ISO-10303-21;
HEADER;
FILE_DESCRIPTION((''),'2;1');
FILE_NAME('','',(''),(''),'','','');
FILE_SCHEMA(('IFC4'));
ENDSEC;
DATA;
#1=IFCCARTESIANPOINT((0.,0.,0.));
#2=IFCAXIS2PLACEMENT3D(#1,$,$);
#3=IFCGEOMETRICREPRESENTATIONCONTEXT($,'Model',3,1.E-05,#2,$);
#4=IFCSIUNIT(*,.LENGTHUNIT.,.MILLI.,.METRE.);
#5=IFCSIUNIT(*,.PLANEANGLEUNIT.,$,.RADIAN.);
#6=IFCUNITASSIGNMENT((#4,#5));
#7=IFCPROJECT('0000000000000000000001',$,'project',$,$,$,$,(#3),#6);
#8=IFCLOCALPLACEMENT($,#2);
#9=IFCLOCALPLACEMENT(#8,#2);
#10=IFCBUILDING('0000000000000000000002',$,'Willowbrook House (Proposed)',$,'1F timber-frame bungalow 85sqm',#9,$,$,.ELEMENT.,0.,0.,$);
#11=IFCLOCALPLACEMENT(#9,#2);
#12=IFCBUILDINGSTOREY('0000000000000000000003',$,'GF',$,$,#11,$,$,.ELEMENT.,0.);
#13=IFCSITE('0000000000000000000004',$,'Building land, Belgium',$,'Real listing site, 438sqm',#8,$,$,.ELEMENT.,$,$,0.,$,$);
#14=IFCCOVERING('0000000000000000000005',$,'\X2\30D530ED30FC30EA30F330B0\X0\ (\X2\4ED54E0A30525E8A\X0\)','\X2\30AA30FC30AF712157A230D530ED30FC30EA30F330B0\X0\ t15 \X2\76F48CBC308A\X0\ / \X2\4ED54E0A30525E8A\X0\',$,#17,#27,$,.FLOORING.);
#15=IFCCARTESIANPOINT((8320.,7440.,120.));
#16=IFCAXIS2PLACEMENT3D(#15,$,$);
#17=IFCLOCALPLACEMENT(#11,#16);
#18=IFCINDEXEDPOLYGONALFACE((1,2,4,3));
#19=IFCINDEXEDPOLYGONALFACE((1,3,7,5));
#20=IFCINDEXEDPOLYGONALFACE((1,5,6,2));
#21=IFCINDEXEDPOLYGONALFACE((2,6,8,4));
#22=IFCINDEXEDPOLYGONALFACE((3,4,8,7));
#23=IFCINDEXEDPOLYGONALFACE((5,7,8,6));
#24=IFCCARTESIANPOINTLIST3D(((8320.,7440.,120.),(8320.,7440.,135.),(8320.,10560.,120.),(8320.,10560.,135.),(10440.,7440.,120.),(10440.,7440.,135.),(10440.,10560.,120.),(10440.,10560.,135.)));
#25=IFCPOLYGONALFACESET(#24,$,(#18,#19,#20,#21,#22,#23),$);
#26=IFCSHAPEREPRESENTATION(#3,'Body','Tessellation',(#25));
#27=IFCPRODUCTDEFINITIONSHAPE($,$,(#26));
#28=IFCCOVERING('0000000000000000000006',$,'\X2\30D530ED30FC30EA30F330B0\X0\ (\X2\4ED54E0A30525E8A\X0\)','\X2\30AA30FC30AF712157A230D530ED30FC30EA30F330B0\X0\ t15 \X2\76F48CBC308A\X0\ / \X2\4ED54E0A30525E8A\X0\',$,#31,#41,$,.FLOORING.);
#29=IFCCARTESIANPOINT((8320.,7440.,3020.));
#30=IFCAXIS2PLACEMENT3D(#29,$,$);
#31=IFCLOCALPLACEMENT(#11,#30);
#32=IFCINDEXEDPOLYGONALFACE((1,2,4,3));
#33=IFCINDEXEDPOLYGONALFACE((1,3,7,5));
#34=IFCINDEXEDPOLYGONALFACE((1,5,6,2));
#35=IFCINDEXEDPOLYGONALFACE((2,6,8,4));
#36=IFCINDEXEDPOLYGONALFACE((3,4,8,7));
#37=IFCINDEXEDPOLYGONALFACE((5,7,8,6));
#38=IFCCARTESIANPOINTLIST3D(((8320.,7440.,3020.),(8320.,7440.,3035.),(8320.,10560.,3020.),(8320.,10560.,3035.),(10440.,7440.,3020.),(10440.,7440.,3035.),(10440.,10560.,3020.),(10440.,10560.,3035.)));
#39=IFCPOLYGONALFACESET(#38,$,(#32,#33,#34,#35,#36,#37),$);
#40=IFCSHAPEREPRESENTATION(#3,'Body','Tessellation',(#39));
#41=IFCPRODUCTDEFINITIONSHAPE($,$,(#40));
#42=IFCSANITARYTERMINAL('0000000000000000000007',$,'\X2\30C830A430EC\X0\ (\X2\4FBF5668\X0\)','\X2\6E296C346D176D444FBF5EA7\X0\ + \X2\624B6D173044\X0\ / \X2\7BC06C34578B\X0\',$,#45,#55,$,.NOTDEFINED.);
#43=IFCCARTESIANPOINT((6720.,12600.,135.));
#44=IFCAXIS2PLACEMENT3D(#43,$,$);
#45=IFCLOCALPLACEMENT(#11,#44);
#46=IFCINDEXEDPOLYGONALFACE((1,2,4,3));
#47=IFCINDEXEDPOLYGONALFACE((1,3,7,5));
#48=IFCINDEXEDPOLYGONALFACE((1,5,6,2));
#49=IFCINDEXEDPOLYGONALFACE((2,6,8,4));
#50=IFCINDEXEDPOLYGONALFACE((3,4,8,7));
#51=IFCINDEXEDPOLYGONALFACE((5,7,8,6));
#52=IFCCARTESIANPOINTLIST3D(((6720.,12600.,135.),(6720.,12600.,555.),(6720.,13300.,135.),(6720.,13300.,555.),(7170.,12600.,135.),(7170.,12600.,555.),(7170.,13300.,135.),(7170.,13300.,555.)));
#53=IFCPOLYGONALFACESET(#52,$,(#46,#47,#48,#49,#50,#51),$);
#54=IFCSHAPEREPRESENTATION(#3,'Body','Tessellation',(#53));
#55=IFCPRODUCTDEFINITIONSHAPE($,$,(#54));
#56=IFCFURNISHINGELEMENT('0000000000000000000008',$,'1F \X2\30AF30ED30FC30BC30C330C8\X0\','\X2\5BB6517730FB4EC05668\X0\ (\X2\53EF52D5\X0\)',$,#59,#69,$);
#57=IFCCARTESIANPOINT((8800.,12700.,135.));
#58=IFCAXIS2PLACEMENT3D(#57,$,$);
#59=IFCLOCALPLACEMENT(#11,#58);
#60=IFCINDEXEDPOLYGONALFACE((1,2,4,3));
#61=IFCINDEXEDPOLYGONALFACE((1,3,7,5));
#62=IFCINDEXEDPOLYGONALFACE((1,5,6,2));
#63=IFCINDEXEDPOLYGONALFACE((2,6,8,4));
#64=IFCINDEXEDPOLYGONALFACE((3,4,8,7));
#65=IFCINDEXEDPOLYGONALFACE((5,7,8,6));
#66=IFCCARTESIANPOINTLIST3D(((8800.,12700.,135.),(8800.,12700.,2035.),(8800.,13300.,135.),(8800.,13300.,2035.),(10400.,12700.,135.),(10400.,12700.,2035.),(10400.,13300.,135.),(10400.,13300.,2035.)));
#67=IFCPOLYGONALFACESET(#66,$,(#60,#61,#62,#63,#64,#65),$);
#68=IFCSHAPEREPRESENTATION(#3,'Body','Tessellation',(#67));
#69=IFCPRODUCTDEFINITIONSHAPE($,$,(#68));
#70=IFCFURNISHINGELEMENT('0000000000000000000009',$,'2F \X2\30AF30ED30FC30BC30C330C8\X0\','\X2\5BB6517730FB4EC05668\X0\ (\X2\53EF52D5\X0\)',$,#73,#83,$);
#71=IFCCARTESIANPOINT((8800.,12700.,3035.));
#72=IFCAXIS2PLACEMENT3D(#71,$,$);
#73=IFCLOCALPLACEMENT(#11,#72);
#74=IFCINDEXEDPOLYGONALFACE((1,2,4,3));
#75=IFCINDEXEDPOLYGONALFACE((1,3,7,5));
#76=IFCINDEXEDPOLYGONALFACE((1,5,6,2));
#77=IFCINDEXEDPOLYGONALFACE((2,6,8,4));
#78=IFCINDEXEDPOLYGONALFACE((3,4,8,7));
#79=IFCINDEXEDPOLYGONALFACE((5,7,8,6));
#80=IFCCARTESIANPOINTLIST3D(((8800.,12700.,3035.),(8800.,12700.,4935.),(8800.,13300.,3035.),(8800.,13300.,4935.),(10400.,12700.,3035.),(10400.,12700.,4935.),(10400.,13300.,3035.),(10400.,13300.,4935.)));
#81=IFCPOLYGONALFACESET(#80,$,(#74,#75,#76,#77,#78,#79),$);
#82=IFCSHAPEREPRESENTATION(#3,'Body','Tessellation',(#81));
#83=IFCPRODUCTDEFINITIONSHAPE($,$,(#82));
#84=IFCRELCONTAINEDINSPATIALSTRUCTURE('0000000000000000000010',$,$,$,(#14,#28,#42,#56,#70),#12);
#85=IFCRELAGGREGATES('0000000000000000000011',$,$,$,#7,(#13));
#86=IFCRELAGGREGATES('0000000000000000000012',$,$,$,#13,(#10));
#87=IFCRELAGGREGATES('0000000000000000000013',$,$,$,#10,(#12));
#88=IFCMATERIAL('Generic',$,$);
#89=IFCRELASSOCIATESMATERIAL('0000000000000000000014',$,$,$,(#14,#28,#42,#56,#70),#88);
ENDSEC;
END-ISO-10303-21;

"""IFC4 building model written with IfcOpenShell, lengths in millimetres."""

from ifc_helpers import new_model, si_unit, frame, frame_2d, origin, place, context, project, spatial, rectangle, extrude, material, element, save


model = new_model("IFC4")

# Units and contexts
model_context = context("Model", 3, precision=1e-05, world=origin())
ifc_project = project(units=[si_unit("LENGTHUNIT", "METRE", prefix="MILLI"), si_unit("PLANEANGLEUNIT", "RADIAN")], contexts=[model_context])

# Site, building, storey
site_placement = place(None, origin())
site = spatial("IfcSite", under=ifc_project, at=site_placement, Name="Building land, Belgium", ObjectType="Real listing site, 438sqm", CompositionType="ELEMENT", RefElevation=0.0)
building_placement = place(site_placement, origin())
building = spatial("IfcBuilding", under=site, at=building_placement, Name="Willowbrook House (Proposed)", ObjectType="1F timber-frame bungalow 85sqm", CompositionType="ELEMENT", ElevationOfRefHeight=0.0, ElevationOfTerrain=0.0)
storey_placement = place(building_placement, origin())
storey = spatial("IfcBuildingStorey", under=building, at=storey_placement, Name="GF", CompositionType="ELEMENT", Elevation=0.0)

# Shared definitions
ifc_material_1 = material(Name="Generic")

# Coverings
covering_1_placement = place(storey_placement, frame((8320.0, 7440.0, 120.0)))
element("IfcCovering", 1, at=covering_1_placement, inside=storey, material=ifc_material_1, Name="フローリング (仕上げ床)", Description="オーク無垢フローリング t15 直貼り / 仕上げ床", PredefinedType="FLOORING", context=model_context, shape_type="SweptSolid", body=[
    extrude(rectangle(XDim=2120.0, YDim=3120.0, at=frame_2d((1060.0, 1560.0))), frame((8320.0, 7440.0, 120.0)), (0.0, 0.0, 1.0), 15.0),
])
covering_2_placement = place(storey_placement, frame((8320.0, 7440.0, 3020.0)))
element("IfcCovering", 2, at=covering_2_placement, inside=storey, material=ifc_material_1, Name="フローリング (仕上げ床)", Description="オーク無垢フローリング t15 直貼り / 仕上げ床", PredefinedType="FLOORING", context=model_context, shape_type="SweptSolid", body=[
    extrude(rectangle(XDim=2120.0, YDim=3120.0, at=frame_2d((1060.0, 1560.0))), frame((8320.0, 7440.0, 3020.0)), (0.0, 0.0, 1.0), 15.0),
])

# Sanitary terminal
sanitary_terminal_placement = place(storey_placement, frame((6720.0, 12600.0, 135.0)))
element("IfcSanitaryTerminal", 3, at=sanitary_terminal_placement, inside=storey, material=ifc_material_1, Name="トイレ (便器)", Description="温水洗浄便座 + 手洗い / 節水型", PredefinedType="NOTDEFINED", context=model_context, shape_type="SweptSolid", body=[
    extrude(rectangle(XDim=450.0, YDim=700.0, at=frame_2d((225.0, 350.0))), frame((6720.0, 12600.0, 135.0)), (0.0, 0.0, 1.0), 420.0),
])

# Furnishing elements
furnishing_1_placement = place(storey_placement, frame((8800.0, 12700.0, 135.0)))
element("IfcFurnishingElement", 4, at=furnishing_1_placement, inside=storey, material=ifc_material_1, Name="1F クローゼット", Description="家具・什器 (可動)", context=model_context, shape_type="SweptSolid", body=[
    extrude(rectangle(XDim=1600.0, YDim=600.0, at=frame_2d((800.0, 300.0))), frame((8800.0, 12700.0, 135.0)), (0.0, 0.0, 1.0), 1900.0),
])
furnishing_2_placement = place(storey_placement, frame((8800.0, 12700.0, 3035.0)))
element("IfcFurnishingElement", 5, at=furnishing_2_placement, inside=storey, material=ifc_material_1, Name="2F クローゼット", Description="家具・什器 (可動)", context=model_context, shape_type="SweptSolid", body=[
    extrude(rectangle(XDim=1600.0, YDim=600.0, at=frame_2d((800.0, 300.0))), frame((8800.0, 12700.0, 3035.0)), (0.0, 0.0, 1.0), 1900.0),
])

save(model, "model.ifc")
